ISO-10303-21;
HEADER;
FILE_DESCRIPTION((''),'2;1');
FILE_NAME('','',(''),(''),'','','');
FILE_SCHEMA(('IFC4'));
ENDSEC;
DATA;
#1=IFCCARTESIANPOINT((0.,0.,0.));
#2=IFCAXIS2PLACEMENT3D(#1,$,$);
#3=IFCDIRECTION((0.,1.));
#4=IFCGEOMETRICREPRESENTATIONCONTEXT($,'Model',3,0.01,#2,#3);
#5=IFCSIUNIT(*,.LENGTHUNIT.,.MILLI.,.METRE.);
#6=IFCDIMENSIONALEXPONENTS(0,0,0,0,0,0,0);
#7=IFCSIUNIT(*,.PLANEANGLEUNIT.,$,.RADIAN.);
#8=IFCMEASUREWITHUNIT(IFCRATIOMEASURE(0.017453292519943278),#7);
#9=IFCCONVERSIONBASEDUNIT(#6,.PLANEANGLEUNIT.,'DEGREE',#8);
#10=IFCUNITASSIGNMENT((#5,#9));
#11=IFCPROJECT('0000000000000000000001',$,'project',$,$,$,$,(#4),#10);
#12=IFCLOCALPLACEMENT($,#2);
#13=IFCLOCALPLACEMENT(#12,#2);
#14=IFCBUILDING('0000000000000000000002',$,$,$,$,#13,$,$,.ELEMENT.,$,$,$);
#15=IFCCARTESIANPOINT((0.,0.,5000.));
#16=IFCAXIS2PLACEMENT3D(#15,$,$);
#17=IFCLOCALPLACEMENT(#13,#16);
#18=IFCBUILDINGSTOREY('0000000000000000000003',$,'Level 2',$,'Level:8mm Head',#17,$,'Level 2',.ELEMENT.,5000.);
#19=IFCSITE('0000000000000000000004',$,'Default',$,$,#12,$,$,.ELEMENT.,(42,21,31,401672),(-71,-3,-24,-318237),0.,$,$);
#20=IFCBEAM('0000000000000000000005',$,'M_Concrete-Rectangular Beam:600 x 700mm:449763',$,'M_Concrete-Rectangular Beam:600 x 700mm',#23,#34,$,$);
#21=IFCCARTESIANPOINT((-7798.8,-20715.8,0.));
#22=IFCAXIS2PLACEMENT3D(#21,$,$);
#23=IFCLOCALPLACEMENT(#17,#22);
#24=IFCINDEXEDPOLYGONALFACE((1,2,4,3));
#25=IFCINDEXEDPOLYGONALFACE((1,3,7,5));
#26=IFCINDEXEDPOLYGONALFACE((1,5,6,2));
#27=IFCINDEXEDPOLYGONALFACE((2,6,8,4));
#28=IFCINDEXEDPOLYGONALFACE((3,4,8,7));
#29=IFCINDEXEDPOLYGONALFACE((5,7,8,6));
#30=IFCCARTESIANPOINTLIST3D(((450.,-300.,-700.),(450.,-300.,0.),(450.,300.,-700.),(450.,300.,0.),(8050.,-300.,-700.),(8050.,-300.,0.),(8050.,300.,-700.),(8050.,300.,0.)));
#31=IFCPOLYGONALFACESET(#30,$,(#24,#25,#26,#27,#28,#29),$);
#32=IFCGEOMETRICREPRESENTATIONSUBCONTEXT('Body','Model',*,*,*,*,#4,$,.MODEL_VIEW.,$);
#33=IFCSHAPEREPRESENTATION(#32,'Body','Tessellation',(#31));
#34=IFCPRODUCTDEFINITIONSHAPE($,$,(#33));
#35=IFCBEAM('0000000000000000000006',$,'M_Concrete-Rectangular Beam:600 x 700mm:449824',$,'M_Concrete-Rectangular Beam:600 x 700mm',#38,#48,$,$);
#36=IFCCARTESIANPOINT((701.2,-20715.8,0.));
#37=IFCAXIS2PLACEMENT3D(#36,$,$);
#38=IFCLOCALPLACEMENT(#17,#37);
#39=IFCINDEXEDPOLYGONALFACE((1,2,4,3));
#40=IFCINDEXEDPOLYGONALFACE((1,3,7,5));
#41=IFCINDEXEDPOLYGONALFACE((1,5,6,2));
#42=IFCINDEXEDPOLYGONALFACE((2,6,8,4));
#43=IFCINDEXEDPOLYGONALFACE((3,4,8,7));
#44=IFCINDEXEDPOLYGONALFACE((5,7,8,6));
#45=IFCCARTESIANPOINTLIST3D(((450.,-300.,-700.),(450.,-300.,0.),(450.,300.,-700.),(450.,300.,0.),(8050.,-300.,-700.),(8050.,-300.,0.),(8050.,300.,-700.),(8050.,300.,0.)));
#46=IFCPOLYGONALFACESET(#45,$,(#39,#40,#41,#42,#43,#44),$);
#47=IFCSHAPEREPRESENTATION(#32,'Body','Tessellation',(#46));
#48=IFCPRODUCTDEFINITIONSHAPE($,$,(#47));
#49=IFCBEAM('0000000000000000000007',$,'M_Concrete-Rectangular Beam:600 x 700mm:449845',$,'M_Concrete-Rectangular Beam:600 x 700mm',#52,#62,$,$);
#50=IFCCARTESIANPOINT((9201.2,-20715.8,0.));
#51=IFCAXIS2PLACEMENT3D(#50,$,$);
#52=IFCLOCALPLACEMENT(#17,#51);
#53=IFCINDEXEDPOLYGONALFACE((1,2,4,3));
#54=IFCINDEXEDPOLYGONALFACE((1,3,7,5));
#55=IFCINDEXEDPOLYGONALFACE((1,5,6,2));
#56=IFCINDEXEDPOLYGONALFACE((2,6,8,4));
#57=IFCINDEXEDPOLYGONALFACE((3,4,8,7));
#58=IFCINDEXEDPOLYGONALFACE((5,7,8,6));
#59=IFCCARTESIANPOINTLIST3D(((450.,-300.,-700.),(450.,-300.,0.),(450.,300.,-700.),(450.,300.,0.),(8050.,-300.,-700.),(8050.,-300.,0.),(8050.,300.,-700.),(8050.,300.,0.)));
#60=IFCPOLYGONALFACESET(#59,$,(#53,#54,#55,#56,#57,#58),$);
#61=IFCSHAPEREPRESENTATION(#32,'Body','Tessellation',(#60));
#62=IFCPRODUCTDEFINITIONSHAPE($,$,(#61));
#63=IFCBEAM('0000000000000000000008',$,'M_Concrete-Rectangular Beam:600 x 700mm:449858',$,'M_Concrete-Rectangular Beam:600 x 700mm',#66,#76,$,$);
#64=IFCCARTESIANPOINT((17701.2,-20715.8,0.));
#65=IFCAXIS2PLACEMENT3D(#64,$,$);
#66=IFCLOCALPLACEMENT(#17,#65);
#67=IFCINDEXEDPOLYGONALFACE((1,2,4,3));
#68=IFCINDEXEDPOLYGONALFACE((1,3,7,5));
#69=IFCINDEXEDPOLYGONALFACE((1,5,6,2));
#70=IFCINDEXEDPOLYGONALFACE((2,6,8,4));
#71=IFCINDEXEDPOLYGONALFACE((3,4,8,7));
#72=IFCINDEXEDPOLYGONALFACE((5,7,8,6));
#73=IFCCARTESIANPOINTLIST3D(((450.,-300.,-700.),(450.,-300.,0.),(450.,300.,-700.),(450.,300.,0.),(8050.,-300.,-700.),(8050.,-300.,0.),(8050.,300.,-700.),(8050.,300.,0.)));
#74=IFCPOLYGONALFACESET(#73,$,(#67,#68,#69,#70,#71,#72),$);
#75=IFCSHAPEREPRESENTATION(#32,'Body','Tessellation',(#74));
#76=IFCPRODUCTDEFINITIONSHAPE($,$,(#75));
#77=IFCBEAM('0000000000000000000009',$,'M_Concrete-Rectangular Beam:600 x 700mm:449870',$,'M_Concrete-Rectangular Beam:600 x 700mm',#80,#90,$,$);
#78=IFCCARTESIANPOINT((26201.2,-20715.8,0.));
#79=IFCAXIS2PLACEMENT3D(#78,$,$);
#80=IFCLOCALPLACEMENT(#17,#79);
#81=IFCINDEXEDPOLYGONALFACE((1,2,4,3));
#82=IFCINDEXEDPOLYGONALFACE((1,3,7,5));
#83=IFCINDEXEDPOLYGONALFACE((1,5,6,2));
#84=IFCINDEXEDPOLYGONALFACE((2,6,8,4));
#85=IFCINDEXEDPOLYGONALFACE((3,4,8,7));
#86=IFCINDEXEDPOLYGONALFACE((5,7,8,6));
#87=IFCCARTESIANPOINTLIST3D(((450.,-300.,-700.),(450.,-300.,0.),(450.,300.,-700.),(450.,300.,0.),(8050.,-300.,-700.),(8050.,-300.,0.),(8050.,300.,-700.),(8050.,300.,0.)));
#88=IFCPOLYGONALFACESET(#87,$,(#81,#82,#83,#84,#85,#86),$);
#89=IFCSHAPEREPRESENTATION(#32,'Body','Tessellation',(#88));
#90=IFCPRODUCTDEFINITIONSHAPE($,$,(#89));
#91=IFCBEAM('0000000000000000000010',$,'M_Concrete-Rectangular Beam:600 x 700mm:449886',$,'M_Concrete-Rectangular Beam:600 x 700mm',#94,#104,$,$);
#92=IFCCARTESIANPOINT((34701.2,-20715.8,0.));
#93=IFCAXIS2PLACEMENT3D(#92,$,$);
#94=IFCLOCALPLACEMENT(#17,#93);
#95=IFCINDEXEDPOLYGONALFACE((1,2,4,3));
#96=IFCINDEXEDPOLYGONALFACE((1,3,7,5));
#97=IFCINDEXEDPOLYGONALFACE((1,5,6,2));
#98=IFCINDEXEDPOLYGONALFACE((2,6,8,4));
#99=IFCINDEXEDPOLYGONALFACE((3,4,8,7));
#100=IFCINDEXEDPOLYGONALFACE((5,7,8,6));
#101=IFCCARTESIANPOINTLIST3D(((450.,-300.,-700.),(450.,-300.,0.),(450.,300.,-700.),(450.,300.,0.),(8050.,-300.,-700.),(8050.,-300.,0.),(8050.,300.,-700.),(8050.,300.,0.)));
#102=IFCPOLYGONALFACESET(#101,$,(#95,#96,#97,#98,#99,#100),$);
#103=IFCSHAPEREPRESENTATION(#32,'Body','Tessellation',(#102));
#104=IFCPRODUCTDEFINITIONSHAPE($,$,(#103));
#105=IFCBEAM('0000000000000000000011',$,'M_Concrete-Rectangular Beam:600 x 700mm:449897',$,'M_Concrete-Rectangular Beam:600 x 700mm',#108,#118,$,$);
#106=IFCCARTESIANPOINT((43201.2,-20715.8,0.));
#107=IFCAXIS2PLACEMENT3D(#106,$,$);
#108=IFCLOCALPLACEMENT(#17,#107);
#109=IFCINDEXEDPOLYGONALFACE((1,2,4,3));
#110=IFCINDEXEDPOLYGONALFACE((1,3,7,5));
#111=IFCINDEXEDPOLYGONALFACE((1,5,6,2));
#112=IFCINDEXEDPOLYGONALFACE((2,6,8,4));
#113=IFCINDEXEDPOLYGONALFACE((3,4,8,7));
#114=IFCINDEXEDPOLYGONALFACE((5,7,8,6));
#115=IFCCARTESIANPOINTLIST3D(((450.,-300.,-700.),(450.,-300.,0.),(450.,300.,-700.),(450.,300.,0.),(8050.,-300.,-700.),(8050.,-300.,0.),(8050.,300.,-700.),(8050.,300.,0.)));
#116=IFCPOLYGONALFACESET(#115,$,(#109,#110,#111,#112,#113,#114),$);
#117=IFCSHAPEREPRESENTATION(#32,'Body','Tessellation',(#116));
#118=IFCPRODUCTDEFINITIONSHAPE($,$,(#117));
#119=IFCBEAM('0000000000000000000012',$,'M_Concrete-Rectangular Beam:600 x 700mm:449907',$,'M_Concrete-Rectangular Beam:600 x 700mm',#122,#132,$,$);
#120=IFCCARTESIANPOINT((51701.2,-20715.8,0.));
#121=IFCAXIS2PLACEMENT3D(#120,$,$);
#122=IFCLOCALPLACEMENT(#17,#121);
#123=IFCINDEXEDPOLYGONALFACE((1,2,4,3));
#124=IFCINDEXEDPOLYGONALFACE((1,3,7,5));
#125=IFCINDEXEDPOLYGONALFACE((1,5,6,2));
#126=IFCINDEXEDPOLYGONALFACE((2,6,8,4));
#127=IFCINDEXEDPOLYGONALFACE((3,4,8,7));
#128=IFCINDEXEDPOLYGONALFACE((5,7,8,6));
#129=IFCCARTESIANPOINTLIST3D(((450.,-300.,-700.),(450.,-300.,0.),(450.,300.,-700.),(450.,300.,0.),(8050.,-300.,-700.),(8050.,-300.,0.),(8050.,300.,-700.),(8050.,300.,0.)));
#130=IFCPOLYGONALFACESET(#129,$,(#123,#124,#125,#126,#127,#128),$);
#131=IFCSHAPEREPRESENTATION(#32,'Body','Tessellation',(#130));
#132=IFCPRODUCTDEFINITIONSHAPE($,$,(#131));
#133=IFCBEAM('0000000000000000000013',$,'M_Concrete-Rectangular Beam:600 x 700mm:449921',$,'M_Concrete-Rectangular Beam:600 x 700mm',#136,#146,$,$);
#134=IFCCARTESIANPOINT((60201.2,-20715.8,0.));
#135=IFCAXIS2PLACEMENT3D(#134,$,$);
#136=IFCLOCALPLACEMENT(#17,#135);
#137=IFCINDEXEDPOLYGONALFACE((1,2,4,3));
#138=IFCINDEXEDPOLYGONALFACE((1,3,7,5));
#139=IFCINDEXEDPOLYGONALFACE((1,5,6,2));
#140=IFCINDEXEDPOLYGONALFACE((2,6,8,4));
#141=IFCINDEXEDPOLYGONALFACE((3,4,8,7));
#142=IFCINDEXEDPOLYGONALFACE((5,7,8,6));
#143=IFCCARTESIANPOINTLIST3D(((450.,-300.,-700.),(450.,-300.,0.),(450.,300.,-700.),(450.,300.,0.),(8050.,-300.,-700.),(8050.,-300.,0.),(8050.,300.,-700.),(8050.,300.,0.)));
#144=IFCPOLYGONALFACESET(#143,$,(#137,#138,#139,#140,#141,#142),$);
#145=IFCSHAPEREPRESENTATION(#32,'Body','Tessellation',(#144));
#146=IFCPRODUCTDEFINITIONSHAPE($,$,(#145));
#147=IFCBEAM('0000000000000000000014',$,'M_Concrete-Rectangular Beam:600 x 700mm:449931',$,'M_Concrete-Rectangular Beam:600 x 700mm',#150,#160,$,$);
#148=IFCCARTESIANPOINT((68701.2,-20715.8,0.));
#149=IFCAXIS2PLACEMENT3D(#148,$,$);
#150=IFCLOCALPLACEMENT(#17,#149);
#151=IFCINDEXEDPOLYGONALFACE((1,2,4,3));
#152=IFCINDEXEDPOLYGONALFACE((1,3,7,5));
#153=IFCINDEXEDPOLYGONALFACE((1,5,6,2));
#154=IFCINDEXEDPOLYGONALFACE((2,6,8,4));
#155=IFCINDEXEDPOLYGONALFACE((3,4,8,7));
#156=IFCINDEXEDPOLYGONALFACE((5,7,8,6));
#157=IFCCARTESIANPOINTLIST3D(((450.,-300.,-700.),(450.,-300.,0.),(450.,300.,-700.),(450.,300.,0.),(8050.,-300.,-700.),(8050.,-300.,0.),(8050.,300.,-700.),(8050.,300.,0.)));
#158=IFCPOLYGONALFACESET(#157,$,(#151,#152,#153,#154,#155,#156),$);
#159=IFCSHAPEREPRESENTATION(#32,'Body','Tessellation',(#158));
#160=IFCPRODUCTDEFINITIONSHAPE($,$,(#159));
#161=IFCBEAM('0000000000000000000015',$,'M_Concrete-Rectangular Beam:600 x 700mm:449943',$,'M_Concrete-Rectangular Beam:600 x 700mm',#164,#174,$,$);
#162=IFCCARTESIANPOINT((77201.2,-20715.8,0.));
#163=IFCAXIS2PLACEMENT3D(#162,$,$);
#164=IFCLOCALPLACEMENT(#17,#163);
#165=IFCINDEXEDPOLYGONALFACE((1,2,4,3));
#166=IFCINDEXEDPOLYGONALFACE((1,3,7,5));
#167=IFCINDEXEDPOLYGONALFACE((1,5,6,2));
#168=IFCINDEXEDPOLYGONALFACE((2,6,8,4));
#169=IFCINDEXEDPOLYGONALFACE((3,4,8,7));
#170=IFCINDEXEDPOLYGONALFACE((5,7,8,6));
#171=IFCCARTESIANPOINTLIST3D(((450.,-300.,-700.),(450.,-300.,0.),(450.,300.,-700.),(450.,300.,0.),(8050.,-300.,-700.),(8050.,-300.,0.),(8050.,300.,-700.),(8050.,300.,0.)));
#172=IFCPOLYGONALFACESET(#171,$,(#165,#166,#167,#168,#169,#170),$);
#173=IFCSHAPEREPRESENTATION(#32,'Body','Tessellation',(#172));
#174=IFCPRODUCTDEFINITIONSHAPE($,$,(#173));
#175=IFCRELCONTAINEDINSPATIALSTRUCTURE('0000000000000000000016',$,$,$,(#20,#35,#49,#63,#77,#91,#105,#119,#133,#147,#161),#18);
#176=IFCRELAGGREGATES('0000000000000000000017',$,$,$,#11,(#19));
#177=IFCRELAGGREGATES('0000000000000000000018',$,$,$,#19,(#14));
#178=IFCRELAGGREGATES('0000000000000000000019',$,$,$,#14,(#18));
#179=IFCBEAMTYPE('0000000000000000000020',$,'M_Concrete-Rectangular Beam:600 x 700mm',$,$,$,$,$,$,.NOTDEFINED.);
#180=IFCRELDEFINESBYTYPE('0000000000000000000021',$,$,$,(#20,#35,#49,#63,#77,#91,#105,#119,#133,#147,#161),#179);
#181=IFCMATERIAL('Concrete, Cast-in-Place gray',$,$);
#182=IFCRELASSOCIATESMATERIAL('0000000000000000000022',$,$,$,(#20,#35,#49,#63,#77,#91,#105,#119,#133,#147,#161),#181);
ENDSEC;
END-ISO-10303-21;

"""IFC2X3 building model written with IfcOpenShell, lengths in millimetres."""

from ifc_helpers import new_model, entity, si_unit, converted_unit, direction, frame, frame_2d, origin, place, context, subcontext, project, spatial, rectangle, extrude, material, type_object, element, save


model = new_model("IFC2X3")

# Units and contexts
model_context = context("Model", 3, precision=0.01, world=origin(), true_north=direction((0.0, 1.0)))
body_context = subcontext(model_context, "Body", "Model", "MODEL_VIEW")
ifc_project = project(units=[si_unit("LENGTHUNIT", "METRE", prefix="MILLI"), converted_unit("PLANEANGLEUNIT", "DEGREE", entity("IfcRatioMeasure", 0.017453292519943278), si_unit("PLANEANGLEUNIT", "RADIAN"), dimensions=[0, 0, 0, 0, 0, 0, 0])], contexts=[model_context])

# Site, building, storey
site_placement = place(None, origin())
site = spatial("IfcSite", under=ifc_project, at=site_placement, Name="Default", CompositionType="ELEMENT", RefLatitude=(42, 21, 31, 401672), RefLongitude=(-71, -3, -24, -318237), RefElevation=0.0)
building_placement = place(site_placement, origin())
building = spatial("IfcBuilding", under=site, at=building_placement, CompositionType="ELEMENT")
storey_placement = place(building_placement, frame((0.0, 0.0, 5000.0)))
storey = spatial("IfcBuildingStorey", under=building, at=storey_placement, Name="Level 2", ObjectType="Level:8mm Head", LongName="Level 2", CompositionType="ELEMENT", Elevation=5000.0)

# Beams
ifc_material_1 = material(Name="Concrete, Cast-in-Place gray")
beam_type = type_object("IfcBeamType", Name="M_Concrete-Rectangular Beam:600 x 700mm", PredefinedType="NOTDEFINED")
beam_1_placement = place(storey_placement, frame((-7798.8, -20715.8, 0.0)))
element("IfcBeam", 1, at=beam_1_placement, inside=storey, type_object=beam_type, material=ifc_material_1, Name="M_Concrete-Rectangular Beam:600 x 700mm:449763", ObjectType="M_Concrete-Rectangular Beam:600 x 700mm", context=body_context, shape_type="SweptSolid", body=[
    extrude(rectangle(XDim=700.0, YDim=600.0, at=frame_2d((0.0, 0.0), x_axis=(1.0, 0.0))), frame((450.0, 0.0, -350.0), z_axis=(1.0, 0.0, 0.0), x_axis=(0.0, 0.0, -1.0)), (0.0, 0.0, 1.0), 7600.0),
])
beam_2_placement = place(storey_placement, frame((701.2, -20715.8, 0.0)))
element("IfcBeam", 2, at=beam_2_placement, inside=storey, type_object=beam_type, material=ifc_material_1, Name="M_Concrete-Rectangular Beam:600 x 700mm:449824", ObjectType="M_Concrete-Rectangular Beam:600 x 700mm", context=body_context, shape_type="SweptSolid", body=[
    extrude(rectangle(XDim=700.0, YDim=600.0, at=frame_2d((0.0, 0.0), x_axis=(1.0, 0.0))), frame((450.0, 0.0, -350.0), z_axis=(1.0, 0.0, 0.0), x_axis=(0.0, 0.0, -1.0)), (0.0, 0.0, 1.0), 7600.0),
])
beam_3_placement = place(storey_placement, frame((9201.2, -20715.8, 0.0)))
element("IfcBeam", 3, at=beam_3_placement, inside=storey, type_object=beam_type, material=ifc_material_1, Name="M_Concrete-Rectangular Beam:600 x 700mm:449845", ObjectType="M_Concrete-Rectangular Beam:600 x 700mm", context=body_context, shape_type="SweptSolid", body=[
    extrude(rectangle(XDim=700.0, YDim=600.0, at=frame_2d((0.0, 0.0), x_axis=(1.0, 0.0))), frame((450.0, 0.0, -350.0), z_axis=(1.0, 0.0, 0.0), x_axis=(0.0, 0.0, -1.0)), (0.0, 0.0, 1.0), 7600.0),
])
beam_4_placement = place(storey_placement, frame((17701.2, -20715.8, 0.0)))
element("IfcBeam", 4, at=beam_4_placement, inside=storey, type_object=beam_type, material=ifc_material_1, Name="M_Concrete-Rectangular Beam:600 x 700mm:449858", ObjectType="M_Concrete-Rectangular Beam:600 x 700mm", context=body_context, shape_type="SweptSolid", body=[
    extrude(rectangle(XDim=700.0, YDim=600.0, at=frame_2d((0.0, 0.0), x_axis=(1.0, 0.0))), frame((450.0, 0.0, -350.0), z_axis=(1.0, 0.0, 0.0), x_axis=(0.0, 0.0, -1.0)), (0.0, 0.0, 1.0), 7600.0),
])
beam_5_placement = place(storey_placement, frame((26201.2, -20715.8, 0.0)))
element("IfcBeam", 5, at=beam_5_placement, inside=storey, type_object=beam_type, material=ifc_material_1, Name="M_Concrete-Rectangular Beam:600 x 700mm:449870", ObjectType="M_Concrete-Rectangular Beam:600 x 700mm", context=body_context, shape_type="SweptSolid", body=[
    extrude(rectangle(XDim=700.0, YDim=600.0, at=frame_2d((0.0, 0.0), x_axis=(1.0, 0.0))), frame((450.0, 0.0, -350.0), z_axis=(1.0, 0.0, 0.0), x_axis=(0.0, 0.0, -1.0)), (0.0, 0.0, 1.0), 7600.0),
])
for number, where, name in (
    (6, (34701.2, -20715.8, 0.0), "M_Concrete-Rectangular Beam:600 x 700mm:449886"),
    (7, (43201.2, -20715.8, 0.0), "M_Concrete-Rectangular Beam:600 x 700mm:449897"),
):
    element("IfcBeam", number, at=place(storey_placement, frame(where)), inside=storey, type_object=beam_type, material=ifc_material_1, Name=name, ObjectType="M_Concrete-Rectangular Beam:600 x 700mm", context=body_context, shape_type="SweptSolid", body=[
        extrude(rectangle(XDim=700.0, YDim=600.0, at=frame_2d((0.0, 0.0), x_axis=(1.0, 0.0))), frame((450.0, 0.0, -350.0), z_axis=(1.0, 0.0, 0.0), x_axis=(0.0, 0.0, -1.0)), (0.0, 0.0, 1.0), 7600.0),
    ])
beam_6_placement = place(storey_placement, frame((51701.2, -20715.8, 0.0)))
element("IfcBeam", 8, at=beam_6_placement, inside=storey, type_object=beam_type, material=ifc_material_1, Name="M_Concrete-Rectangular Beam:600 x 700mm:449907", ObjectType="M_Concrete-Rectangular Beam:600 x 700mm", context=body_context, shape_type="SweptSolid", body=[
    extrude(rectangle(XDim=700.0, YDim=600.0, at=frame_2d((0.0, 0.0), x_axis=(1.0, 0.0))), frame((450.0, 0.0, -350.0), z_axis=(1.0, 0.0, 0.0), x_axis=(0.0, 0.0, -1.0)), (0.0, 0.0, 1.0), 7600.0),
])
beam_7_placement = place(storey_placement, frame((60201.2, -20715.8, 0.0)))
element("IfcBeam", 9, at=beam_7_placement, inside=storey, type_object=beam_type, material=ifc_material_1, Name="M_Concrete-Rectangular Beam:600 x 700mm:449921", ObjectType="M_Concrete-Rectangular Beam:600 x 700mm", context=body_context, shape_type="SweptSolid", body=[
    extrude(rectangle(XDim=700.0, YDim=600.0, at=frame_2d((0.0, 0.0), x_axis=(1.0, 0.0))), frame((450.0, 0.0, -350.0), z_axis=(1.0, 0.0, 0.0), x_axis=(0.0, 0.0, -1.0)), (0.0, 0.0, 1.0), 7600.0),
])
beam_8_placement = place(storey_placement, frame((68701.2, -20715.8, 0.0)))
element("IfcBeam", 10, at=beam_8_placement, inside=storey, type_object=beam_type, material=ifc_material_1, Name="M_Concrete-Rectangular Beam:600 x 700mm:449931", ObjectType="M_Concrete-Rectangular Beam:600 x 700mm", context=body_context, shape_type="SweptSolid", body=[
    extrude(rectangle(XDim=700.0, YDim=600.0, at=frame_2d((0.0, 0.0), x_axis=(1.0, 0.0))), frame((450.0, 0.0, -350.0), z_axis=(1.0, 0.0, 0.0), x_axis=(0.0, 0.0, -1.0)), (0.0, 0.0, 1.0), 7600.0),
])
beam_9_placement = place(storey_placement, frame((77201.2, -20715.8, 0.0)))
element("IfcBeam", 11, at=beam_9_placement, inside=storey, type_object=beam_type, material=ifc_material_1, Name="M_Concrete-Rectangular Beam:600 x 700mm:449943", ObjectType="M_Concrete-Rectangular Beam:600 x 700mm", context=body_context, shape_type="SweptSolid", body=[
    extrude(rectangle(XDim=700.0, YDim=600.0, at=frame_2d((0.0, 0.0), x_axis=(1.0, 0.0))), frame((450.0, 0.0, -350.0), z_axis=(1.0, 0.0, 0.0), x_axis=(0.0, 0.0, -1.0)), (0.0, 0.0, 1.0), 7600.0),
])

save(model, "model.ifc")
